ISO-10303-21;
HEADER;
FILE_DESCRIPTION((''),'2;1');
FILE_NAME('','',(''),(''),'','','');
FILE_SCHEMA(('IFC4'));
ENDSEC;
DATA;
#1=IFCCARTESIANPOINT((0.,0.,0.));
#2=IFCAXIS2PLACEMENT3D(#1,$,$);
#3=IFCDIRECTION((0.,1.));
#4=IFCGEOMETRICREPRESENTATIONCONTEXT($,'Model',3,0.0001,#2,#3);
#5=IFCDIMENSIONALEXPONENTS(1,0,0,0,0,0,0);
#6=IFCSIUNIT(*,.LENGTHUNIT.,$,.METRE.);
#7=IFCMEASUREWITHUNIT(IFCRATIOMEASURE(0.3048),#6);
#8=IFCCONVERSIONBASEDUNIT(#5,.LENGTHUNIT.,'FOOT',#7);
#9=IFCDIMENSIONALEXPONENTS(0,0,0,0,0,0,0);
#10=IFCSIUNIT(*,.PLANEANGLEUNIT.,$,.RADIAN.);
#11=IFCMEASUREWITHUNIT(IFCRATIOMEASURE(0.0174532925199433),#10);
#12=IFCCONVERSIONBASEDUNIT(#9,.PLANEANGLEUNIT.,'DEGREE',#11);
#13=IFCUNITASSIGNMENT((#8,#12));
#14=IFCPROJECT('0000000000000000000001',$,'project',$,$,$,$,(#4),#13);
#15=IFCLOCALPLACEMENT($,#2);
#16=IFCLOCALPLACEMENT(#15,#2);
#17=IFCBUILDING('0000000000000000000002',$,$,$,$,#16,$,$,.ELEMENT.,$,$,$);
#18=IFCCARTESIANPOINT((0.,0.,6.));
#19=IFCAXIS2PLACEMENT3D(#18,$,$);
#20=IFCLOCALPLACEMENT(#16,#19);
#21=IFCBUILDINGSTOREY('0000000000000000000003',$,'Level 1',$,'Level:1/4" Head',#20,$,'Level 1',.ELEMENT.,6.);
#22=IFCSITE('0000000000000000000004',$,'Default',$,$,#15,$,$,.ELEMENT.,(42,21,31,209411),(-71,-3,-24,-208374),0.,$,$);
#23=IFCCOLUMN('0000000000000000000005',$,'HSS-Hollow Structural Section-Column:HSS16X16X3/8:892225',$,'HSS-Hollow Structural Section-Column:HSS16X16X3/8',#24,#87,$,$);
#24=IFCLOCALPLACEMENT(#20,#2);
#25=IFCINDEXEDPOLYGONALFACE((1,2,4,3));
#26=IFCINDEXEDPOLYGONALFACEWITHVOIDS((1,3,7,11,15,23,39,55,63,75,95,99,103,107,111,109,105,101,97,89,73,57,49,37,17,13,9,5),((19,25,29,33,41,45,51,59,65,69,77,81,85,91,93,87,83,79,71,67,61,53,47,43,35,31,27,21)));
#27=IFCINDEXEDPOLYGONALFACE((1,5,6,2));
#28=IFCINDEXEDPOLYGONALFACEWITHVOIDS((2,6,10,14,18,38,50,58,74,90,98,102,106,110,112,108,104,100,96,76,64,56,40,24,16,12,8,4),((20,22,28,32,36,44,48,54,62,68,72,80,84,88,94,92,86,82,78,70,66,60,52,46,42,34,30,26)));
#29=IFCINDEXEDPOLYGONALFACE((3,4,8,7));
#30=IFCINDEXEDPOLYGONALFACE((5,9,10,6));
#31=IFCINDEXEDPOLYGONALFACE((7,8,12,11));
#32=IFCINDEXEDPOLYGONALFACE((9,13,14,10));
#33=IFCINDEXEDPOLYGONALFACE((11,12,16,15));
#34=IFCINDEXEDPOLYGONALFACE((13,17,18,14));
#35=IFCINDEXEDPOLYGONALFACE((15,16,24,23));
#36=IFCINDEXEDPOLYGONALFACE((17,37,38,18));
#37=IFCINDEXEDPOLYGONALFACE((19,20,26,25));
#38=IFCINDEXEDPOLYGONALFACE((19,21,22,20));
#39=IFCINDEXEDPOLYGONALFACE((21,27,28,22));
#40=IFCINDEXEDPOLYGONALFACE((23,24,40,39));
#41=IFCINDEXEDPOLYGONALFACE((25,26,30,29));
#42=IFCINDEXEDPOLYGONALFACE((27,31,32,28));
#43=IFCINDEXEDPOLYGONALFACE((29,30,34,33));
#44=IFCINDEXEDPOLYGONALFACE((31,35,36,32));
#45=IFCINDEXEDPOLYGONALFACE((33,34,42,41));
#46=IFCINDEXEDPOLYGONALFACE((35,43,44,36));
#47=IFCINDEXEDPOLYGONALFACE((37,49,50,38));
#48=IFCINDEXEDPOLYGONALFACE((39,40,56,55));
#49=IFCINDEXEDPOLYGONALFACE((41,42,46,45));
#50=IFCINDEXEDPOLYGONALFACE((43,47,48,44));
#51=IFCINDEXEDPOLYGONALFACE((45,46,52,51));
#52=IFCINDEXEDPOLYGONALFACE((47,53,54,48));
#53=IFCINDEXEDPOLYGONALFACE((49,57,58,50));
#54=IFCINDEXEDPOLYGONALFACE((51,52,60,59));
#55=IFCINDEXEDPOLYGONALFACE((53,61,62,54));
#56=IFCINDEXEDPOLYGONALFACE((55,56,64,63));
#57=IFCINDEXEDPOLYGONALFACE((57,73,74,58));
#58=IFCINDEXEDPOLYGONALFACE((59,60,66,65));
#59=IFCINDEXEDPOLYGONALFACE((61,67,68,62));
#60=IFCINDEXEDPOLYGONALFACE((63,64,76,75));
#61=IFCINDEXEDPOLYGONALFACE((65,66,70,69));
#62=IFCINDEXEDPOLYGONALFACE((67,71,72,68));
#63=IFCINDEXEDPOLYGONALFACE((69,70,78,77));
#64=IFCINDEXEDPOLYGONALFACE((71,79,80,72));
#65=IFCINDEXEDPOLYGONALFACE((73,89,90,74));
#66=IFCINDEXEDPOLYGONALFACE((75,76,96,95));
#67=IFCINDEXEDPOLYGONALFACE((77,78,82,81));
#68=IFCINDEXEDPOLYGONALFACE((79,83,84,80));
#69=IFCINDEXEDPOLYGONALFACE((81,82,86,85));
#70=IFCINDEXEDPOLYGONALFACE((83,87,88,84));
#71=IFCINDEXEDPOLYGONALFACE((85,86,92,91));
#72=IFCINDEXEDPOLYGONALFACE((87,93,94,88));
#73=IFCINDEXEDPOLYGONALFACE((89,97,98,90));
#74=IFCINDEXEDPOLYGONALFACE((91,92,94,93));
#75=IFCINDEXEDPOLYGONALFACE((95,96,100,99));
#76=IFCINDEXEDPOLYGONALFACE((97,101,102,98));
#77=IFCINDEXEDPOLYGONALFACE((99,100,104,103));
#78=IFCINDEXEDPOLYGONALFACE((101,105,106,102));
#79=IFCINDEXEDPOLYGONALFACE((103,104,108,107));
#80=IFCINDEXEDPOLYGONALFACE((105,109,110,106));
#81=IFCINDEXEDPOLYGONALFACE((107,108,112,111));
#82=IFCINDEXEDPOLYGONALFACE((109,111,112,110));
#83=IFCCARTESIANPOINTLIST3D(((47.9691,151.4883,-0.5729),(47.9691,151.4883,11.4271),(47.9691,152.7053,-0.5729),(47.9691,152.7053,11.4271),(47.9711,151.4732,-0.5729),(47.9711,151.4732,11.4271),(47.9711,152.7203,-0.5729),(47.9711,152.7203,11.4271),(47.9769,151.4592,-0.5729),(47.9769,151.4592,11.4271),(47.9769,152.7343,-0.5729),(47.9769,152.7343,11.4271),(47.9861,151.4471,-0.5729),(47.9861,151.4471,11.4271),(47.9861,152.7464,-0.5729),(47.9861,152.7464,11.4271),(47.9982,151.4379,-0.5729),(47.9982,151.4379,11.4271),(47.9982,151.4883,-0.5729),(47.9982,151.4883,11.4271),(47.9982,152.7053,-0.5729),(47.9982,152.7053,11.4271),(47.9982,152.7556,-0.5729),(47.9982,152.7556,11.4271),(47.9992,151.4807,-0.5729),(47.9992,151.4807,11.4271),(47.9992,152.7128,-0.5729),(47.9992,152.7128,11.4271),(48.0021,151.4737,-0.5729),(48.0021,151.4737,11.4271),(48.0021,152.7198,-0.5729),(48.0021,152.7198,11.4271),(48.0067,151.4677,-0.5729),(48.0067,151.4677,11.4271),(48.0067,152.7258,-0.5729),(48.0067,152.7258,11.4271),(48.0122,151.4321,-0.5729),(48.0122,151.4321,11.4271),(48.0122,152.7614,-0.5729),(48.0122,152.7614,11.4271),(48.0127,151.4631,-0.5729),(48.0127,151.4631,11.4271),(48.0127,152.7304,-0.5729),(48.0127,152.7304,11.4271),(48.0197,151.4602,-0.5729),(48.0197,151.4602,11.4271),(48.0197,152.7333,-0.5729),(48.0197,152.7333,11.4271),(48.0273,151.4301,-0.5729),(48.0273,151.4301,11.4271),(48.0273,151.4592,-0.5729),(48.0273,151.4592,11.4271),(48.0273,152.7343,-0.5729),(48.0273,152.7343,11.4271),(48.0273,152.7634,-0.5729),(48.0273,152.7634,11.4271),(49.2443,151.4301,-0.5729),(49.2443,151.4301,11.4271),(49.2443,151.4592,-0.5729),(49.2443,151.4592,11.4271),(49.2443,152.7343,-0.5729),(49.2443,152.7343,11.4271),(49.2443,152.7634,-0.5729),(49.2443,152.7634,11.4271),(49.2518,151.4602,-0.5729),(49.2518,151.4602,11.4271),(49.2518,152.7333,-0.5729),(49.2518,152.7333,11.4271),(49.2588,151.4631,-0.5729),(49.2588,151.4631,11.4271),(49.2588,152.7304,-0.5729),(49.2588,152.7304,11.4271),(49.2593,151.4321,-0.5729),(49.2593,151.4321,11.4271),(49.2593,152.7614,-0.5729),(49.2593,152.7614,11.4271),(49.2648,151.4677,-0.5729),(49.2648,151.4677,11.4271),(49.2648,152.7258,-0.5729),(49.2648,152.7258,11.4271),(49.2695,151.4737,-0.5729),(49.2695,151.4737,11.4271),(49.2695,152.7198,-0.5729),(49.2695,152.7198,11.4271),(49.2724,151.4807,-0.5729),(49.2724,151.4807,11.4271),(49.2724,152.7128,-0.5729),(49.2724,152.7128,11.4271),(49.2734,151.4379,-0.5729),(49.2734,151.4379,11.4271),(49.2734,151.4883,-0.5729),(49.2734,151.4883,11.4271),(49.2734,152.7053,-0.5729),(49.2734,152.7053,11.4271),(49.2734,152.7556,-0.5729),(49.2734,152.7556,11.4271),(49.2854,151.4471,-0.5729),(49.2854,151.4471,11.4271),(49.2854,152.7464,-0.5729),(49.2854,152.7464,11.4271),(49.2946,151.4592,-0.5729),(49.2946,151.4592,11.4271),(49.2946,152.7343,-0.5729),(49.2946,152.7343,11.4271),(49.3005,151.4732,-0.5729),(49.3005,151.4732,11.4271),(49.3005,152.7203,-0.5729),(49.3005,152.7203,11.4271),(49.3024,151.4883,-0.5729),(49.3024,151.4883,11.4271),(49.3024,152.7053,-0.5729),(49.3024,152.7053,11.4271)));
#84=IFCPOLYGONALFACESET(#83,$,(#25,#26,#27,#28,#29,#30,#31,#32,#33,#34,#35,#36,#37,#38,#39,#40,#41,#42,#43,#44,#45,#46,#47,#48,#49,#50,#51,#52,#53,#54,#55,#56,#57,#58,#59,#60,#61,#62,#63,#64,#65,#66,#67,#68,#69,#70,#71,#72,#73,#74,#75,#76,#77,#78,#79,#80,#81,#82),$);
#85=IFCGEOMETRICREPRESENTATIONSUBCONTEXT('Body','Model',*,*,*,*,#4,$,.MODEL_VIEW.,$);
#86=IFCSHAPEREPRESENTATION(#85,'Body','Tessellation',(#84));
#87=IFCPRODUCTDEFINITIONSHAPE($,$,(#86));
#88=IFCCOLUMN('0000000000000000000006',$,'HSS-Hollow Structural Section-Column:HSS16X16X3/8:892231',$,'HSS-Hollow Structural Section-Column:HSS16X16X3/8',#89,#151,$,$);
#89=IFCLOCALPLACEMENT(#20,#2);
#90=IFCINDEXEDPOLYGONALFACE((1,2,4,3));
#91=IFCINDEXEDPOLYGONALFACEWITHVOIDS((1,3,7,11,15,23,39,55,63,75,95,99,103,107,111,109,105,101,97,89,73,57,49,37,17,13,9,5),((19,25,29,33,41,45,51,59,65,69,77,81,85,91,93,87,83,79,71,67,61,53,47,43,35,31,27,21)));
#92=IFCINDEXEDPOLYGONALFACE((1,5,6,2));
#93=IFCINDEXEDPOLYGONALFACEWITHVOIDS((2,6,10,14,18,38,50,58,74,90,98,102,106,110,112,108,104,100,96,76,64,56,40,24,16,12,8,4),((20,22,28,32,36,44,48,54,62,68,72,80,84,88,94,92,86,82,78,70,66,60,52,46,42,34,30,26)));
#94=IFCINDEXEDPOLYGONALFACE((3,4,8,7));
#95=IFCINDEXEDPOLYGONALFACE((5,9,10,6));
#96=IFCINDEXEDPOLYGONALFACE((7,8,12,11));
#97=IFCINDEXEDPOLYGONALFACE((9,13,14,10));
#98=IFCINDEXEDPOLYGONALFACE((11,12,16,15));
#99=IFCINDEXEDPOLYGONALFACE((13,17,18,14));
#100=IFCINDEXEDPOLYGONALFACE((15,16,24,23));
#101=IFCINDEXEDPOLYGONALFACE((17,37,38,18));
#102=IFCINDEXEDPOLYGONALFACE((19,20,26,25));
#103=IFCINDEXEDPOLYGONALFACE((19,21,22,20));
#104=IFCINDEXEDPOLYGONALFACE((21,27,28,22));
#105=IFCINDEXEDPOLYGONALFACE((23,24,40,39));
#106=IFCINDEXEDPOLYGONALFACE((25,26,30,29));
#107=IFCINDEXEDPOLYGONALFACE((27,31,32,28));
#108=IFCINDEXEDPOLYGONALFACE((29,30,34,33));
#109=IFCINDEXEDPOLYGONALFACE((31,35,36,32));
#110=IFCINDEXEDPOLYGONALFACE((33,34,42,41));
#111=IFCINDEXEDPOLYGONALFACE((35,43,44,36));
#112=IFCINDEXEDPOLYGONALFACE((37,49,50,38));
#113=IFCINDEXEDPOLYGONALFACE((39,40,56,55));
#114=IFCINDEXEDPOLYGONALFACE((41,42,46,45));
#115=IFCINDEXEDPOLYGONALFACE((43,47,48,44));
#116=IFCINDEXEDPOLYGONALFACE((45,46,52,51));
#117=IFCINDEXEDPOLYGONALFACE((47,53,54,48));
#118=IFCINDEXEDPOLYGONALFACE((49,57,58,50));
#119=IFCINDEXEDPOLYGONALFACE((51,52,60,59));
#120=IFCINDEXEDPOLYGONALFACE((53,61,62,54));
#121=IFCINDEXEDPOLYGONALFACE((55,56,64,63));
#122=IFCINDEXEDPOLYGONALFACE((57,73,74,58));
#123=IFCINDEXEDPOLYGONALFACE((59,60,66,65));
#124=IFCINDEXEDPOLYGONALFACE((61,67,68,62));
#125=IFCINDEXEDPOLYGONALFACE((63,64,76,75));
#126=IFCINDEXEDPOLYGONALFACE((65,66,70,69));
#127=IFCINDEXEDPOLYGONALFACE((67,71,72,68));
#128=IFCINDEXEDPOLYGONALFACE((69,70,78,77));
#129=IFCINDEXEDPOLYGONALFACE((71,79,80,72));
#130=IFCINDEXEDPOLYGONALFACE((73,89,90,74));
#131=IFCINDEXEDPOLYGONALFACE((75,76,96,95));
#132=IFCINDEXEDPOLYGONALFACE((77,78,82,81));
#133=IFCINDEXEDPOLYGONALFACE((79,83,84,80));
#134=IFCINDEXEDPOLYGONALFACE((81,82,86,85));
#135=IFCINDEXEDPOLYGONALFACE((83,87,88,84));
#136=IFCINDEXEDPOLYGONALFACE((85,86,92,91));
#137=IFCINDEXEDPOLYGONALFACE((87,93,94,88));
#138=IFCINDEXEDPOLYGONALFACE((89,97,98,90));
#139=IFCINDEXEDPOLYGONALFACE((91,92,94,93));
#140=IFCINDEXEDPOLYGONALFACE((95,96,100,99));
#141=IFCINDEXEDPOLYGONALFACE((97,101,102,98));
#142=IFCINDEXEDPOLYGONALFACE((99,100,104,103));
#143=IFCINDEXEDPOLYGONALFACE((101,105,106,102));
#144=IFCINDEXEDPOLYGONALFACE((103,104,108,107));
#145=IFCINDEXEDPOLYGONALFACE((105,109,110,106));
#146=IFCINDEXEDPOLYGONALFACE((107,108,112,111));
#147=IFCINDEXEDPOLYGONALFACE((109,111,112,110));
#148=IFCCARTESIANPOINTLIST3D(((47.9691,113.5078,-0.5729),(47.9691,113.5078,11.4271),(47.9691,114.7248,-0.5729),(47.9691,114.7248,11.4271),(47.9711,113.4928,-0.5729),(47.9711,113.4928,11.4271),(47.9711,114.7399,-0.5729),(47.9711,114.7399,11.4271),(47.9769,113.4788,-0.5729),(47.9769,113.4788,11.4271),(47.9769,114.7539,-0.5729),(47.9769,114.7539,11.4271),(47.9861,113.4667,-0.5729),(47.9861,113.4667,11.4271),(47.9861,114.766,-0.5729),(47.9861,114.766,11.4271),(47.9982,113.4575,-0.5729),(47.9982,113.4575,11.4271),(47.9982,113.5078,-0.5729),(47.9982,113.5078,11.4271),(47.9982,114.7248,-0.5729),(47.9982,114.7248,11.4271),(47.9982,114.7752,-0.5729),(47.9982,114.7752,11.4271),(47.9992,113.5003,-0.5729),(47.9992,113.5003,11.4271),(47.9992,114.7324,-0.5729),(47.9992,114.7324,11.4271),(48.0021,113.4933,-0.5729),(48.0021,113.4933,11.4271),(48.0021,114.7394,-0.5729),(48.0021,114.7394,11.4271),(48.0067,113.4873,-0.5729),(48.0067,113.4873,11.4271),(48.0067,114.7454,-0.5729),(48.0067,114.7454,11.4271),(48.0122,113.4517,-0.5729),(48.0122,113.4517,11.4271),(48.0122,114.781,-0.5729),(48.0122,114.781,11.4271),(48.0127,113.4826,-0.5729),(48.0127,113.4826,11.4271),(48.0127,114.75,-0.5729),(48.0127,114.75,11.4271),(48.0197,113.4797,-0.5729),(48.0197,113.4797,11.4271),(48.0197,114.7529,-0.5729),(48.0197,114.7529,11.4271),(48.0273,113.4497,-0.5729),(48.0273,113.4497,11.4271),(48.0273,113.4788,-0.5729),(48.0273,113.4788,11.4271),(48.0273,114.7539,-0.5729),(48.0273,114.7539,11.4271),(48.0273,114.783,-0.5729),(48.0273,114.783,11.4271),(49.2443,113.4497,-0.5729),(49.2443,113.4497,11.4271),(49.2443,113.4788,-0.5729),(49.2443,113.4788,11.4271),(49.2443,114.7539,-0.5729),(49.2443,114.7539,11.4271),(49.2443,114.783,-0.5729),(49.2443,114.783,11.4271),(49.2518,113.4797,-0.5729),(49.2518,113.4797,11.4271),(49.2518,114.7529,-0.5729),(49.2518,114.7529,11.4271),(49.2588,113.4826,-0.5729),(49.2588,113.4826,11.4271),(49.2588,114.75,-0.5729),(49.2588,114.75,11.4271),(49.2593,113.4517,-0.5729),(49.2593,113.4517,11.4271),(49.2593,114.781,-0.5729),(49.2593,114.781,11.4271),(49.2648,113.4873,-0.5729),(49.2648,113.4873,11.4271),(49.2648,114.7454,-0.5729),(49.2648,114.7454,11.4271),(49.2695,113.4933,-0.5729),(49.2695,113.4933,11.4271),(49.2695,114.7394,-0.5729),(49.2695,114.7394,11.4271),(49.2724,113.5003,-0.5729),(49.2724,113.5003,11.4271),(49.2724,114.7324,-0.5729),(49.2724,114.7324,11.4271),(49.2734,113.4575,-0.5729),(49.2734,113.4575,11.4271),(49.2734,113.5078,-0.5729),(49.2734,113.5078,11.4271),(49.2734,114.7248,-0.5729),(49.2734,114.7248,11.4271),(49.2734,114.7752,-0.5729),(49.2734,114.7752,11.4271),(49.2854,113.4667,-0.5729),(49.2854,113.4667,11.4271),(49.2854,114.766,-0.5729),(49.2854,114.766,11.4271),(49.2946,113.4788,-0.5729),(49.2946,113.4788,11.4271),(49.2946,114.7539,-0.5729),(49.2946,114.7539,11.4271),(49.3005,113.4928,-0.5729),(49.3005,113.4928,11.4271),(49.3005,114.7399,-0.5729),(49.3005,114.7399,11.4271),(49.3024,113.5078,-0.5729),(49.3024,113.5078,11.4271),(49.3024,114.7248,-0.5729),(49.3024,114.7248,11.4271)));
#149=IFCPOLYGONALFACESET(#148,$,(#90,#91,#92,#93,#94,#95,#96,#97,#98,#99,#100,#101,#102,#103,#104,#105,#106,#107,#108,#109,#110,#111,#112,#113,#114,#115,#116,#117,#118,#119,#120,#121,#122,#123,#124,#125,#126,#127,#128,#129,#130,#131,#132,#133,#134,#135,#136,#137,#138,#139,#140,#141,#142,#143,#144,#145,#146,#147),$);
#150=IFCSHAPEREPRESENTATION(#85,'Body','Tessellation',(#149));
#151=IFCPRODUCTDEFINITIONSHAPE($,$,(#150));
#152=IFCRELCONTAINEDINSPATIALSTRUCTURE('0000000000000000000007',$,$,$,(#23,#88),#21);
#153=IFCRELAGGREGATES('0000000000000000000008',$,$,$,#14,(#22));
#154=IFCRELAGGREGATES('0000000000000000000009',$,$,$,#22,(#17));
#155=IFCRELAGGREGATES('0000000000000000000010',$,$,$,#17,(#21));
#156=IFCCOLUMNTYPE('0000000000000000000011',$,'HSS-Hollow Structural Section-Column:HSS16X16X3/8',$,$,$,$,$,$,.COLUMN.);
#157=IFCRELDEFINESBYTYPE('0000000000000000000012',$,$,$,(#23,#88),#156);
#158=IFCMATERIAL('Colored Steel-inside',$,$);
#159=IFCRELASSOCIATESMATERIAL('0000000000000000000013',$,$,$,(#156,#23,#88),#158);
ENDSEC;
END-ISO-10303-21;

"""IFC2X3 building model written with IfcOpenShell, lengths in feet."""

from ifc_helpers import new_model, entity, si_unit, converted_unit, direction, frame, frame_2d, origin, place, context, subcontext, project, spatial, polyline, circle_curve, parameter, trimmed, segment, composite_curve, outline, extrude, source, transform, mapped, material, type_object, type_shapes, element, save


model = new_model("IFC2X3")

# Units and contexts
model_context = context("Model", 3, precision=0.0001, world=origin(), true_north=direction((0.0, 1.0)))
body_context = subcontext(model_context, "Body", "Model", "MODEL_VIEW")
ifc_project = project(units=[converted_unit("LENGTHUNIT", "FOOT", entity("IfcRatioMeasure", 0.3048), si_unit("LENGTHUNIT", "METRE"), dimensions=[1, 0, 0, 0, 0, 0, 0]), converted_unit("PLANEANGLEUNIT", "DEGREE", entity("IfcRatioMeasure", 0.0174532925199433), si_unit("PLANEANGLEUNIT", "RADIAN"), dimensions=[0, 0, 0, 0, 0, 0, 0])], contexts=[model_context])

# Site, building, storey
site_placement = place(None, origin())
site = spatial("IfcSite", under=ifc_project, at=site_placement, Name="Default", CompositionType="ELEMENT", RefLatitude=(42, 21, 31, 209411), RefLongitude=(-71, -3, -24, -208374), RefElevation=0.0)
building_placement = place(site_placement, origin())
building = spatial("IfcBuilding", under=site, at=building_placement, CompositionType="ELEMENT")
storey_placement = place(building_placement, frame((0.0, 0.0, 6.0)))
storey = spatial("IfcBuildingStorey", under=building, at=storey_placement, Name="Level 1", ObjectType="Level:1/4\" Head", LongName="Level 1", CompositionType="ELEMENT", Elevation=6.0)

# Columns
ifc_material_1 = material(Name="Colored Steel-inside")
column_type_1 = type_object("IfcColumnType", Name="HSS-Hollow Structural Section-Column:HSS16X16X3/8", PredefinedType="COLUMN", material=ifc_material_1)
shared_shape_1 = source(origin(), body_context, "Body", "SweptSolid", [
    extrude(outline(composite_curve([segment(polyline([(-0.6085, -0.6667), (0.6085, -0.6667)]), True, "CONTINUOUS"), segment(trimmed(circle_curve(frame_2d((0.6085, -0.6085), x_axis=(-1.0, 0.0)), 0.0582), [parameter(90.0)], [parameter(180.0)], True, "PARAMETER"), True, "CONTINUOUS"), segment(polyline([(0.6667, -0.6085), (0.6667, 0.6085)]), True, "CONTINUOUS"), segment(trimmed(circle_curve(frame_2d((0.6085, 0.6085), x_axis=(-1.0, 0.0)), 0.0582), [parameter(180.0)], [parameter(270.0)], True, "PARAMETER"), True, "CONTINUOUS"), segment(polyline([(0.6085, 0.6667), (-0.6085, 0.6667)]), True, "CONTINUOUS"), segment(trimmed(circle_curve(frame_2d((-0.6085, 0.6085), x_axis=(-1.0, 0.0)), 0.0582), [parameter(270.0)], [parameter(360.0)], True, "PARAMETER"), True, "CONTINUOUS"), segment(polyline([(-0.6667, 0.6085), (-0.6667, -0.6085)]), True, "CONTINUOUS"), segment(trimmed(circle_curve(frame_2d((-0.6085, -0.6085), x_axis=(-1.0, 0.0)), 0.0582), [parameter(360.0)], [parameter(90.0)], True, "PARAMETER"), True, "CONTINUOUS")], self_intersect=False), holes=[composite_curve([segment(trimmed(circle_curve(frame_2d((-0.6085, -0.6085), x_axis=(-1.0, 0.0)), 0.0291), [parameter(0.0)], [parameter(90.0)], True, "PARAMETER"), False, "CONTINUOUS"), segment(polyline([(-0.6376, -0.6085), (-0.6376, 0.6085)]), True, "CONTINUOUS"), segment(trimmed(circle_curve(frame_2d((-0.6085, 0.6085), x_axis=(-1.0, 0.0)), 0.0291), [parameter(270.0)], [parameter(360.0)], True, "PARAMETER"), False, "CONTINUOUS"), segment(polyline([(-0.6085, 0.6376), (0.6085, 0.6376)]), True, "CONTINUOUS"), segment(trimmed(circle_curve(frame_2d((0.6085, 0.6085), x_axis=(-1.0, 0.0)), 0.0291), [parameter(180.0)], [parameter(270.0)], True, "PARAMETER"), False, "CONTINUOUS"), segment(polyline([(0.6376, 0.6085), (0.6376, -0.6085)]), True, "CONTINUOUS"), segment(trimmed(circle_curve(frame_2d((0.6085, -0.6085), x_axis=(-1.0, 0.0)), 0.0291), [parameter(90.0)], [parameter(180.0)], True, "PARAMETER"), False, "CONTINUOUS"), segment(polyline([(0.6085, -0.6376), (-0.6085, -0.6376)]), True, "CONTINUOUS")], self_intersect=False)]), frame((0.0, 0.0, 5.4271), z_axis=(0.0, 0.0, 1.0), x_axis=(-1.0, 0.0, 0.0)), (0.0, 0.0, 1.0), 12.0),
])
type_shapes(column_type_1, [shared_shape_1])
for number, where, name in (
    (1, (48.6358, 152.0968, -6.0), "HSS-Hollow Structural Section-Column:HSS16X16X3/8:892225"),
    (2, (48.6358, 114.1163, -6.0), "HSS-Hollow Structural Section-Column:HSS16X16X3/8:892231"),
):
    element("IfcColumn", number, at=place(storey_placement, frame(where)), inside=storey, type_object=column_type_1, material=ifc_material_1, Name=name, ObjectType="HSS-Hollow Structural Section-Column:HSS16X16X3/8", context=body_context, shape_type="MappedRepresentation", body=[
        mapped(shared_shape_1, transform((0.0, 0.0, 0.0), scale=1.0)),
    ])

save(model, "model.ifc")
